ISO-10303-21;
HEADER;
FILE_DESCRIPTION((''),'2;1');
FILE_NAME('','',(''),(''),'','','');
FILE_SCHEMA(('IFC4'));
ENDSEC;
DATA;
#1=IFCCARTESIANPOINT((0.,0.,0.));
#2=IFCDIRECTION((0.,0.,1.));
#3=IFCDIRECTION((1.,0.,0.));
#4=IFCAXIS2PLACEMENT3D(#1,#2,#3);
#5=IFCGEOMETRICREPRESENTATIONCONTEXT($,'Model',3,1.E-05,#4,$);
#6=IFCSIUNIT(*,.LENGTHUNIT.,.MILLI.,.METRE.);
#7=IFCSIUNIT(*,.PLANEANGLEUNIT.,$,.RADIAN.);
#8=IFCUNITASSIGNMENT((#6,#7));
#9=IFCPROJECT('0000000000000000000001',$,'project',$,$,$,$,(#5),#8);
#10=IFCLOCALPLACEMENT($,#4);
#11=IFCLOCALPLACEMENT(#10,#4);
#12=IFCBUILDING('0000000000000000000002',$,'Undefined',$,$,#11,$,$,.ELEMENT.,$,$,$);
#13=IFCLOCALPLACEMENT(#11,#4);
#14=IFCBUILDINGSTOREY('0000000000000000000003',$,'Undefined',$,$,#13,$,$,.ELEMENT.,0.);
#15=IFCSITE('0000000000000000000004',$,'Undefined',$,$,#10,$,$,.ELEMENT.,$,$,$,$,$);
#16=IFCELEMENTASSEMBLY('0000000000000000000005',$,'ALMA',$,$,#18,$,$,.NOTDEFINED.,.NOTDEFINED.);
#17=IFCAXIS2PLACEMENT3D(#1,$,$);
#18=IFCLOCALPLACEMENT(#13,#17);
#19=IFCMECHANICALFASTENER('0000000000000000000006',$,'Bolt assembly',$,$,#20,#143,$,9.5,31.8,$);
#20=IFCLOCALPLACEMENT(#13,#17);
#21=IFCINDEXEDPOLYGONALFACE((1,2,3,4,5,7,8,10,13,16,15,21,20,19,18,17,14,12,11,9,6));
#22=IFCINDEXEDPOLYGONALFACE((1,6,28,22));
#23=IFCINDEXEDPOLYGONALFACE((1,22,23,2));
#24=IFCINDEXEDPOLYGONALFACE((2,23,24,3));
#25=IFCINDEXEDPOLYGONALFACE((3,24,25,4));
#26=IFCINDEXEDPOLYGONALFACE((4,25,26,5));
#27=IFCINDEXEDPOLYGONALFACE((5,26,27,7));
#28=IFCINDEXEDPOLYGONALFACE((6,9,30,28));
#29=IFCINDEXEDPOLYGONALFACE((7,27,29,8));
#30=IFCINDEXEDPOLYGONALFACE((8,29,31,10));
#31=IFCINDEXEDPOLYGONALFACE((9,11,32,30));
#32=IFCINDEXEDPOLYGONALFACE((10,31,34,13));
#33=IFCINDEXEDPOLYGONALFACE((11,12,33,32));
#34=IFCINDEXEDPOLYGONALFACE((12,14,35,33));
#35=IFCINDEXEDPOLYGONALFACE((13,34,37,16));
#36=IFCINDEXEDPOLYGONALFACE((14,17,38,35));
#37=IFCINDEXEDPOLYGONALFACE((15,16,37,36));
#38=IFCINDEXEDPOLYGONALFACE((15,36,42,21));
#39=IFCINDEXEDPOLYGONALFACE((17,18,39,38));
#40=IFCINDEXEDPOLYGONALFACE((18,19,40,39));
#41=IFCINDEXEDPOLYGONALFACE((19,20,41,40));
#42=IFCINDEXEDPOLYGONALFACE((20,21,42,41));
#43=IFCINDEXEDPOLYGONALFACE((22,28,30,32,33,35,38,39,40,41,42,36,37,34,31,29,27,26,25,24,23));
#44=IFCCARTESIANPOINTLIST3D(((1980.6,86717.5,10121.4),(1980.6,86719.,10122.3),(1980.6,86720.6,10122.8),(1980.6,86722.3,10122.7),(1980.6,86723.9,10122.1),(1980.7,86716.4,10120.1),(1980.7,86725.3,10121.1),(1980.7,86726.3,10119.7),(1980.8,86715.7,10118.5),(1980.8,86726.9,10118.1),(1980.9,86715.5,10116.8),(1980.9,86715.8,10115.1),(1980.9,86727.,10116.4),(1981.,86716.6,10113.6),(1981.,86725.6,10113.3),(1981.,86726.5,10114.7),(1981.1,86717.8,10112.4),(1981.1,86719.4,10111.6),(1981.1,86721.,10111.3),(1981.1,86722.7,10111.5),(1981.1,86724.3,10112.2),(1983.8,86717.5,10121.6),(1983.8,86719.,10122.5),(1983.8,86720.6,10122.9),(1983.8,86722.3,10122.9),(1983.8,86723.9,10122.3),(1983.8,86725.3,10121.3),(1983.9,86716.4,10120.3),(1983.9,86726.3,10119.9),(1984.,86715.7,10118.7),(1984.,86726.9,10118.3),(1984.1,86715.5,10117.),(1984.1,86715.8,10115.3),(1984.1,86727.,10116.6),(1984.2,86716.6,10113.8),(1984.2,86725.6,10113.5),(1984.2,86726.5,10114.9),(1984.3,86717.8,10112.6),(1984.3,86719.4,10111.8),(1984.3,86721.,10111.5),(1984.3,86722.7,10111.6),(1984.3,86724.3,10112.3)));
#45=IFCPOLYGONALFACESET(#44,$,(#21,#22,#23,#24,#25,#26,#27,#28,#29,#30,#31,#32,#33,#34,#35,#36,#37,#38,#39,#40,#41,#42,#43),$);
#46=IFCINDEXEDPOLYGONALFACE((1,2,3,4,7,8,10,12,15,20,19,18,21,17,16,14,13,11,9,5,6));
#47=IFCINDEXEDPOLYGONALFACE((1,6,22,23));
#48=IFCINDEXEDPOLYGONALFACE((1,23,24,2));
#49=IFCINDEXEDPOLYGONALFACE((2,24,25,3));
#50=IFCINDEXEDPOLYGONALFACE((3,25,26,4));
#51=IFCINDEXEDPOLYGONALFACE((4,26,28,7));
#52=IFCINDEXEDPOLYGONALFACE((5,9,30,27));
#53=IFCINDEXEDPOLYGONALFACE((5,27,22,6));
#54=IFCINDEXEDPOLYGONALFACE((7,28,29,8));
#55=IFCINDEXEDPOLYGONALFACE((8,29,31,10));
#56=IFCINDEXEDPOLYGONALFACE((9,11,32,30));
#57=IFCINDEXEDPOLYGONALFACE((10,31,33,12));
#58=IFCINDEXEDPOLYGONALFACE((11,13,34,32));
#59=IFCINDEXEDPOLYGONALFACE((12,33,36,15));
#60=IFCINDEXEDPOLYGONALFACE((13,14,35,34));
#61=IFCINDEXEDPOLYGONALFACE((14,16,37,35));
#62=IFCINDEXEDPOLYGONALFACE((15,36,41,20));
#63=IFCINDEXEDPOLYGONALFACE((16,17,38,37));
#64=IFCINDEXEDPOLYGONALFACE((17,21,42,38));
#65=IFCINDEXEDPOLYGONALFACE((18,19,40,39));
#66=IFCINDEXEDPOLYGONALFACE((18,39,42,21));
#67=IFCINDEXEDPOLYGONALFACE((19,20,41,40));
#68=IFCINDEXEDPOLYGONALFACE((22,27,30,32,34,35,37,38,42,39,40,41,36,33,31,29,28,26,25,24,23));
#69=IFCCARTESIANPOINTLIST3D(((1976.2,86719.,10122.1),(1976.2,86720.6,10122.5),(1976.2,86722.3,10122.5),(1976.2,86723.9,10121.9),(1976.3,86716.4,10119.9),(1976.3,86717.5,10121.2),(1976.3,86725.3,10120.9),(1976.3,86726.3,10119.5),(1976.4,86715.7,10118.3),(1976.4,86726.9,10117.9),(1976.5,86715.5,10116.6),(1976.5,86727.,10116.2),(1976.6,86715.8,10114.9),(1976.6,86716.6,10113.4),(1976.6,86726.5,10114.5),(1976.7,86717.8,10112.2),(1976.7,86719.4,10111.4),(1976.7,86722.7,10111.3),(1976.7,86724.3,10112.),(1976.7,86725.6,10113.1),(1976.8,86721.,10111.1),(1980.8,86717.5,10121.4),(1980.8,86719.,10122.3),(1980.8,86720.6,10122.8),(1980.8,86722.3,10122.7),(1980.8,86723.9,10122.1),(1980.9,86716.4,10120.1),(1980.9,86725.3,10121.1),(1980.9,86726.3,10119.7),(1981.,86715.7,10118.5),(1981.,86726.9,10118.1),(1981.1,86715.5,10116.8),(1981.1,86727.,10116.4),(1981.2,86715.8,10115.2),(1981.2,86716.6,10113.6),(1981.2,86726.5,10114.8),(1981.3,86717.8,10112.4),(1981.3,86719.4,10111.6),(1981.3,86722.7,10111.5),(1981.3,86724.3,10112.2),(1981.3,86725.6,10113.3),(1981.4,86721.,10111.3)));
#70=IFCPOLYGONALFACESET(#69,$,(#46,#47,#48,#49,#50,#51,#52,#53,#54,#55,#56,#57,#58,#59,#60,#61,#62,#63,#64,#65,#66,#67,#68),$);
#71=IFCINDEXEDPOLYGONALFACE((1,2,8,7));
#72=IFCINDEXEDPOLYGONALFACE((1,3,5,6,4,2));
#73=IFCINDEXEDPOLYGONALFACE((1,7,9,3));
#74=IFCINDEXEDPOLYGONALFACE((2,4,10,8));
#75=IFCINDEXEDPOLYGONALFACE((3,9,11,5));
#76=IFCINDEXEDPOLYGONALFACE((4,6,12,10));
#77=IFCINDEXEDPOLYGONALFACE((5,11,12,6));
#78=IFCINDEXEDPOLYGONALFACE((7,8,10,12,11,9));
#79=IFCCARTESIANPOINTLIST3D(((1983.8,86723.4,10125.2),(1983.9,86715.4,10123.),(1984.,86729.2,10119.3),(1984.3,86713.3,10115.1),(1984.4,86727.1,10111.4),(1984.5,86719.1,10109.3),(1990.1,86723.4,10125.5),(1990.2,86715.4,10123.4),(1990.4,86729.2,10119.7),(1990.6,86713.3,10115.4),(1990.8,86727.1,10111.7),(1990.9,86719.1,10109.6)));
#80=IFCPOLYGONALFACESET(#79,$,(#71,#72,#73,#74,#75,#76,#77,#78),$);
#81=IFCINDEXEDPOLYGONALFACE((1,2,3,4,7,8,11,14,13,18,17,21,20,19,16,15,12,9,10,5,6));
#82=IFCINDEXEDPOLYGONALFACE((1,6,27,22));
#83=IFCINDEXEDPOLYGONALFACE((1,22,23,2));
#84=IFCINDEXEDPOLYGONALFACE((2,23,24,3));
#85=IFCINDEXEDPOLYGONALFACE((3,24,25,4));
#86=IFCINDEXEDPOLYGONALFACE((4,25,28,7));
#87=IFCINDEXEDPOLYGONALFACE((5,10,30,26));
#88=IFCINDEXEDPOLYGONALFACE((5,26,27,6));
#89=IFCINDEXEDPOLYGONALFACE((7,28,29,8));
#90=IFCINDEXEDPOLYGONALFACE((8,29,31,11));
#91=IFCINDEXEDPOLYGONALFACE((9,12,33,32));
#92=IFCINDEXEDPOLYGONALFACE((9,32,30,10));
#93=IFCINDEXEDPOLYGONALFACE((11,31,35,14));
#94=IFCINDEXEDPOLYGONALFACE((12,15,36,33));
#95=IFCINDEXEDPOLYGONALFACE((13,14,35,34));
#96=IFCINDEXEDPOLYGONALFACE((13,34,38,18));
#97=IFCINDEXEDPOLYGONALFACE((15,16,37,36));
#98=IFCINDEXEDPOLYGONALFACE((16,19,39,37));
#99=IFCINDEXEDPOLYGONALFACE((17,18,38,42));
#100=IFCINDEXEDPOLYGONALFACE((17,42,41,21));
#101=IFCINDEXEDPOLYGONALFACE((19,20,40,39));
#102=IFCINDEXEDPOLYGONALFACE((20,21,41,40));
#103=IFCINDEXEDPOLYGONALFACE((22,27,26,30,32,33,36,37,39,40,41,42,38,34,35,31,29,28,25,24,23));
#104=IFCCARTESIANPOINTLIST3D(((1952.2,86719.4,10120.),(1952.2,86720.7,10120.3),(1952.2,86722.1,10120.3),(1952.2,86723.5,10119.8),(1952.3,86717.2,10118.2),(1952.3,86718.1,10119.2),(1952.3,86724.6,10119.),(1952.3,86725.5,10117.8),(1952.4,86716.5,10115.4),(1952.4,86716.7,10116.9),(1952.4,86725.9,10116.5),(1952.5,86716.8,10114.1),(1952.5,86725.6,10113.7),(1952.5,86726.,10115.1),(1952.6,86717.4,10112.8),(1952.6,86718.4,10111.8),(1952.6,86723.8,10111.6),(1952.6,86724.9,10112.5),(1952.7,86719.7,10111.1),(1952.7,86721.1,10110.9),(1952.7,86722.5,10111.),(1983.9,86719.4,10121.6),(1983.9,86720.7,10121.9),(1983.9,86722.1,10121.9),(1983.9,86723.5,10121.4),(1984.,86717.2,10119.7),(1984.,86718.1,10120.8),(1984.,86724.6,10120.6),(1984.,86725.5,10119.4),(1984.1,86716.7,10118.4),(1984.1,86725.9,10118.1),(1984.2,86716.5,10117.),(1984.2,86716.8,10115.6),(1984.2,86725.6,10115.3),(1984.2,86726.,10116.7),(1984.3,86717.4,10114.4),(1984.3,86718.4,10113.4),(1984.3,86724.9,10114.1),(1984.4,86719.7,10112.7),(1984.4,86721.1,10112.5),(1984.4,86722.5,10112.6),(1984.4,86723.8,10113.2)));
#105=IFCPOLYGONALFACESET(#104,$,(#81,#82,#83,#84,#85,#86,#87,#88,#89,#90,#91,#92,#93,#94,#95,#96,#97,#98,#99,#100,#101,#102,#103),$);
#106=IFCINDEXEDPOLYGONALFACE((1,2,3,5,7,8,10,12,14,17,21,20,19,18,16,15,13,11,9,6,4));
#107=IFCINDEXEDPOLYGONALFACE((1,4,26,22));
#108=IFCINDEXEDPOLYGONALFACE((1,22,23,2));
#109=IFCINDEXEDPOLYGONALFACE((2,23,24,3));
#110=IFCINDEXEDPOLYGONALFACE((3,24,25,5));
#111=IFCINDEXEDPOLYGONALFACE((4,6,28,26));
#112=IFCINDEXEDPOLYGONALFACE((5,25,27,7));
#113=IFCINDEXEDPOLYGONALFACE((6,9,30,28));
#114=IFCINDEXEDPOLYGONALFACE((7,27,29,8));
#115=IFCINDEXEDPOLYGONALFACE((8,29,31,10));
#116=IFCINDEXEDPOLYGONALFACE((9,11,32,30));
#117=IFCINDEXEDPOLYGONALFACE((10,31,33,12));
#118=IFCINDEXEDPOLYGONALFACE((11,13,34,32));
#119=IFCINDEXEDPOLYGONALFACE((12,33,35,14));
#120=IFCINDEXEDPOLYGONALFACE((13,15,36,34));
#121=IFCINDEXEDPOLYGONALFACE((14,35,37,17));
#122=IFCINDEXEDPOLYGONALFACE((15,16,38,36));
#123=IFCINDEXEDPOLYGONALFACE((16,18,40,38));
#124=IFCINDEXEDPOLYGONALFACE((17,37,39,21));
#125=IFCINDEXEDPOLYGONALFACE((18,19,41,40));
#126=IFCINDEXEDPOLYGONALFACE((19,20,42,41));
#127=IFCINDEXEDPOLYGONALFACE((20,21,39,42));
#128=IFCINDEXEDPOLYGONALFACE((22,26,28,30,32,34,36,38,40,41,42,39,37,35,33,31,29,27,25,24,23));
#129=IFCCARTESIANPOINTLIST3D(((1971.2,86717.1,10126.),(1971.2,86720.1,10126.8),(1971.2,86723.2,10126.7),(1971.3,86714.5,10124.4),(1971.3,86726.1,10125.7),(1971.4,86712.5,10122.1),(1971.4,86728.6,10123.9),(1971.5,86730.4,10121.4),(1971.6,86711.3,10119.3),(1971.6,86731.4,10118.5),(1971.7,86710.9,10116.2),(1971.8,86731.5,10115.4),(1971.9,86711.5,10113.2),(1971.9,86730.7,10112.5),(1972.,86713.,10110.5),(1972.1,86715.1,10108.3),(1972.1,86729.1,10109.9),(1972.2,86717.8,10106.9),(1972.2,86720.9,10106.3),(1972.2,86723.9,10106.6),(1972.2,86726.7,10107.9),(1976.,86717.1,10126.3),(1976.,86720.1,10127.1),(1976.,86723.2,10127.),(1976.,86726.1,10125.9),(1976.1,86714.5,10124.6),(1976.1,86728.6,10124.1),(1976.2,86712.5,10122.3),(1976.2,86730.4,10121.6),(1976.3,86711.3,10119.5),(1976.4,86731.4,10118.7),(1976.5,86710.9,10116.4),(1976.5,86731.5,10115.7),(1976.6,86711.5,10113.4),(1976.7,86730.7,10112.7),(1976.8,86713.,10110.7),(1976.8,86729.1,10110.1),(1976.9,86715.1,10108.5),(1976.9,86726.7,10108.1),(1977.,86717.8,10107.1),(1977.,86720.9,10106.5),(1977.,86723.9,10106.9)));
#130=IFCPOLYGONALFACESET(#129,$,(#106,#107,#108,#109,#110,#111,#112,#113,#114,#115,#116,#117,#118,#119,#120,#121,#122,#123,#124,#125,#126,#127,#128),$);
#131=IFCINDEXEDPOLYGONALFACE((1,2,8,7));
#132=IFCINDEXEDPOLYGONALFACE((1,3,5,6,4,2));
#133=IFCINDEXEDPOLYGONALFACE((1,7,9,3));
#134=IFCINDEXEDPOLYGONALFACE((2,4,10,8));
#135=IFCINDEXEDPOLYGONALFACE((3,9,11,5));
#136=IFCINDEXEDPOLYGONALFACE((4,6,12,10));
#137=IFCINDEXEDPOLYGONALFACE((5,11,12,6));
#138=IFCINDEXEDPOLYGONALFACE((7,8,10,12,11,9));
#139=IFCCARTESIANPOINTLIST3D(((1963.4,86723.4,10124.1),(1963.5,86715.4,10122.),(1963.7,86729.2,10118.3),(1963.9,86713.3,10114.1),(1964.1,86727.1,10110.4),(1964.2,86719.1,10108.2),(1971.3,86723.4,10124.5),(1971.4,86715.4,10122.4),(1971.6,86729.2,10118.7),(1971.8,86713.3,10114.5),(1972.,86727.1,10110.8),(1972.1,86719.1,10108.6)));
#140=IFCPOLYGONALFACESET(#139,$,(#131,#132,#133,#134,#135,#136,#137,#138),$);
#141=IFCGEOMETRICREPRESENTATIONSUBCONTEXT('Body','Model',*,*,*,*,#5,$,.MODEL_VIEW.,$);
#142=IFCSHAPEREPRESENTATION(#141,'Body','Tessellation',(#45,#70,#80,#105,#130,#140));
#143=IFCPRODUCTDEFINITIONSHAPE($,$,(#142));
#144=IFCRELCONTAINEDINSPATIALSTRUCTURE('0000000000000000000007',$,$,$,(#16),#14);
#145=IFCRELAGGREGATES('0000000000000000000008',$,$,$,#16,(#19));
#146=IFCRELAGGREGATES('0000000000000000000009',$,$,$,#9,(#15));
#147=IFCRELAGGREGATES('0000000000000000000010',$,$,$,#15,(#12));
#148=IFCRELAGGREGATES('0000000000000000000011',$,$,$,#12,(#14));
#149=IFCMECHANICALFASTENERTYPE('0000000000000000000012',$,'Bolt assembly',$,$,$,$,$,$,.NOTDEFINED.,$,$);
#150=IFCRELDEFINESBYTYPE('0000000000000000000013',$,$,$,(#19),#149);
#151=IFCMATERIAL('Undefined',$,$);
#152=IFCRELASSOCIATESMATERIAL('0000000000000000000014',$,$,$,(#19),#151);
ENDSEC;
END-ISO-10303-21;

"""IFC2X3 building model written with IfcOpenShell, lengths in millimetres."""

from ifc_helpers import new_model, si_unit, frame, origin_with_axes, origin_2d_with_axis, place, context, subcontext, project, spatial, polyline, circle, outline, extrude, source, transform, mapped, material, type_object, element, aggregate, save


model = new_model("IFC2X3")

# Units and contexts
model_context = context("Model", 3, precision=1e-05, world=origin_with_axes())
body_context = subcontext(model_context, "Body", "Model", "MODEL_VIEW")
ifc_project = project(units=[si_unit("LENGTHUNIT", "METRE", prefix="MILLI"), si_unit("PLANEANGLEUNIT", "RADIAN")], contexts=[model_context])

# Site, building, storey
site_placement = place(None, origin_with_axes())
site = spatial("IfcSite", under=ifc_project, at=site_placement, Name="Undefined", CompositionType="ELEMENT")
building_placement = place(site_placement, origin_with_axes())
building = spatial("IfcBuilding", under=site, at=building_placement, Name="Undefined", CompositionType="ELEMENT")
storey_placement = place(building_placement, origin_with_axes())
storey = spatial("IfcBuildingStorey", under=building, at=storey_placement, Name="Undefined", CompositionType="ELEMENT", Elevation=0.0)

# Element assembly
assembly_1_placement = place(storey_placement, origin_with_axes())
assembly_1 = element("IfcElementAssembly", 1, at=assembly_1_placement, inside=storey, Name="ALMA", AssemblyPlace="NOTDEFINED", PredefinedType="NOTDEFINED")

# Shared definitions
ifc_material_1 = material(Name="Undefined")
mechanical_fastener_type = type_object("IfcMechanicalFastenerType", Name="Bolt assembly")

# Mechanical fastener
shared_shape_1 = source(origin_with_axes(), body_context, "Body", "SweptSolid", [
    extrude(circle(Radius=5.8, at=origin_2d_with_axis()), frame((0.0, -7.6, 0.0), z_axis=(0.0, 1.0, 0.0), x_axis=(1.0, 0.0, 0.0)), (0.0, 0.0, 1.0), 3.2),
    extrude(circle(Radius=5.8, at=origin_2d_with_axis()), frame((0.0, -4.6, 0.0), z_axis=(0.0, 1.0, 0.0), x_axis=(1.0, 0.0, 0.0)), (0.0, 0.0, 1.0), 4.6),
    extrude(outline(polyline([(7.1, -4.1), (7.1, 4.1), (0.0, 8.2), (-7.1, 4.1), (-7.1, -4.1), (0.0, -8.2), (7.1, -4.1)])), frame((0.0, -14.0, 0.0), z_axis=(0.0, 1.0, 0.0), x_axis=(1.0, 0.0, 0.0)), (0.0, 0.0, 1.0), 6.3),
    extrude(circle(Radius=4.8, at=origin_2d_with_axis()), frame((0.0, -7.7, 0.0), z_axis=(0.0, 1.0, 0.0), x_axis=(1.0, 0.0, 0.0)), (0.0, 0.0, 1.0), 31.8),
    extrude(circle(Radius=10.3, at=origin_2d_with_axis()), frame((0.0, 0.0, 0.0), z_axis=(0.0, 1.0, 0.0), x_axis=(1.0, 0.0, 0.0)), (0.0, 0.0, 1.0), 4.8),
    extrude(outline(polyline([(7.1, -4.1), (7.1, 4.1), (0.0, 8.2), (-7.1, 4.1), (-7.1, -4.1), (0.0, -8.2), (7.1, -4.1)])), frame((0.0, 4.8, 0.0), z_axis=(0.0, 1.0, 0.0), x_axis=(1.0, 0.0, 0.0)), (0.0, 0.0, 1.0), 7.9),
])
mechanical_fastener_1_placement = place(assembly_1_placement, frame((1976.5, 86721.3, 10116.8), z_axis=(-0.035282, -0.707107, 0.706226), x_axis=(-0.035281, 0.707107, 0.706226)))
mechanical_fastener_1 = element("IfcMechanicalFastener", 2, at=mechanical_fastener_1_placement, type_object=mechanical_fastener_type, material=ifc_material_1, Name="Bolt assembly", NominalDiameter=9.5, NominalLength=31.8, context=body_context, shape_type="MappedRepresentation", body=[
    mapped(shared_shape_1, transform((0.0, 0.0, 0.0))),
])
aggregate(assembly_1, [mechanical_fastener_1])

save(model, "model.ifc")
